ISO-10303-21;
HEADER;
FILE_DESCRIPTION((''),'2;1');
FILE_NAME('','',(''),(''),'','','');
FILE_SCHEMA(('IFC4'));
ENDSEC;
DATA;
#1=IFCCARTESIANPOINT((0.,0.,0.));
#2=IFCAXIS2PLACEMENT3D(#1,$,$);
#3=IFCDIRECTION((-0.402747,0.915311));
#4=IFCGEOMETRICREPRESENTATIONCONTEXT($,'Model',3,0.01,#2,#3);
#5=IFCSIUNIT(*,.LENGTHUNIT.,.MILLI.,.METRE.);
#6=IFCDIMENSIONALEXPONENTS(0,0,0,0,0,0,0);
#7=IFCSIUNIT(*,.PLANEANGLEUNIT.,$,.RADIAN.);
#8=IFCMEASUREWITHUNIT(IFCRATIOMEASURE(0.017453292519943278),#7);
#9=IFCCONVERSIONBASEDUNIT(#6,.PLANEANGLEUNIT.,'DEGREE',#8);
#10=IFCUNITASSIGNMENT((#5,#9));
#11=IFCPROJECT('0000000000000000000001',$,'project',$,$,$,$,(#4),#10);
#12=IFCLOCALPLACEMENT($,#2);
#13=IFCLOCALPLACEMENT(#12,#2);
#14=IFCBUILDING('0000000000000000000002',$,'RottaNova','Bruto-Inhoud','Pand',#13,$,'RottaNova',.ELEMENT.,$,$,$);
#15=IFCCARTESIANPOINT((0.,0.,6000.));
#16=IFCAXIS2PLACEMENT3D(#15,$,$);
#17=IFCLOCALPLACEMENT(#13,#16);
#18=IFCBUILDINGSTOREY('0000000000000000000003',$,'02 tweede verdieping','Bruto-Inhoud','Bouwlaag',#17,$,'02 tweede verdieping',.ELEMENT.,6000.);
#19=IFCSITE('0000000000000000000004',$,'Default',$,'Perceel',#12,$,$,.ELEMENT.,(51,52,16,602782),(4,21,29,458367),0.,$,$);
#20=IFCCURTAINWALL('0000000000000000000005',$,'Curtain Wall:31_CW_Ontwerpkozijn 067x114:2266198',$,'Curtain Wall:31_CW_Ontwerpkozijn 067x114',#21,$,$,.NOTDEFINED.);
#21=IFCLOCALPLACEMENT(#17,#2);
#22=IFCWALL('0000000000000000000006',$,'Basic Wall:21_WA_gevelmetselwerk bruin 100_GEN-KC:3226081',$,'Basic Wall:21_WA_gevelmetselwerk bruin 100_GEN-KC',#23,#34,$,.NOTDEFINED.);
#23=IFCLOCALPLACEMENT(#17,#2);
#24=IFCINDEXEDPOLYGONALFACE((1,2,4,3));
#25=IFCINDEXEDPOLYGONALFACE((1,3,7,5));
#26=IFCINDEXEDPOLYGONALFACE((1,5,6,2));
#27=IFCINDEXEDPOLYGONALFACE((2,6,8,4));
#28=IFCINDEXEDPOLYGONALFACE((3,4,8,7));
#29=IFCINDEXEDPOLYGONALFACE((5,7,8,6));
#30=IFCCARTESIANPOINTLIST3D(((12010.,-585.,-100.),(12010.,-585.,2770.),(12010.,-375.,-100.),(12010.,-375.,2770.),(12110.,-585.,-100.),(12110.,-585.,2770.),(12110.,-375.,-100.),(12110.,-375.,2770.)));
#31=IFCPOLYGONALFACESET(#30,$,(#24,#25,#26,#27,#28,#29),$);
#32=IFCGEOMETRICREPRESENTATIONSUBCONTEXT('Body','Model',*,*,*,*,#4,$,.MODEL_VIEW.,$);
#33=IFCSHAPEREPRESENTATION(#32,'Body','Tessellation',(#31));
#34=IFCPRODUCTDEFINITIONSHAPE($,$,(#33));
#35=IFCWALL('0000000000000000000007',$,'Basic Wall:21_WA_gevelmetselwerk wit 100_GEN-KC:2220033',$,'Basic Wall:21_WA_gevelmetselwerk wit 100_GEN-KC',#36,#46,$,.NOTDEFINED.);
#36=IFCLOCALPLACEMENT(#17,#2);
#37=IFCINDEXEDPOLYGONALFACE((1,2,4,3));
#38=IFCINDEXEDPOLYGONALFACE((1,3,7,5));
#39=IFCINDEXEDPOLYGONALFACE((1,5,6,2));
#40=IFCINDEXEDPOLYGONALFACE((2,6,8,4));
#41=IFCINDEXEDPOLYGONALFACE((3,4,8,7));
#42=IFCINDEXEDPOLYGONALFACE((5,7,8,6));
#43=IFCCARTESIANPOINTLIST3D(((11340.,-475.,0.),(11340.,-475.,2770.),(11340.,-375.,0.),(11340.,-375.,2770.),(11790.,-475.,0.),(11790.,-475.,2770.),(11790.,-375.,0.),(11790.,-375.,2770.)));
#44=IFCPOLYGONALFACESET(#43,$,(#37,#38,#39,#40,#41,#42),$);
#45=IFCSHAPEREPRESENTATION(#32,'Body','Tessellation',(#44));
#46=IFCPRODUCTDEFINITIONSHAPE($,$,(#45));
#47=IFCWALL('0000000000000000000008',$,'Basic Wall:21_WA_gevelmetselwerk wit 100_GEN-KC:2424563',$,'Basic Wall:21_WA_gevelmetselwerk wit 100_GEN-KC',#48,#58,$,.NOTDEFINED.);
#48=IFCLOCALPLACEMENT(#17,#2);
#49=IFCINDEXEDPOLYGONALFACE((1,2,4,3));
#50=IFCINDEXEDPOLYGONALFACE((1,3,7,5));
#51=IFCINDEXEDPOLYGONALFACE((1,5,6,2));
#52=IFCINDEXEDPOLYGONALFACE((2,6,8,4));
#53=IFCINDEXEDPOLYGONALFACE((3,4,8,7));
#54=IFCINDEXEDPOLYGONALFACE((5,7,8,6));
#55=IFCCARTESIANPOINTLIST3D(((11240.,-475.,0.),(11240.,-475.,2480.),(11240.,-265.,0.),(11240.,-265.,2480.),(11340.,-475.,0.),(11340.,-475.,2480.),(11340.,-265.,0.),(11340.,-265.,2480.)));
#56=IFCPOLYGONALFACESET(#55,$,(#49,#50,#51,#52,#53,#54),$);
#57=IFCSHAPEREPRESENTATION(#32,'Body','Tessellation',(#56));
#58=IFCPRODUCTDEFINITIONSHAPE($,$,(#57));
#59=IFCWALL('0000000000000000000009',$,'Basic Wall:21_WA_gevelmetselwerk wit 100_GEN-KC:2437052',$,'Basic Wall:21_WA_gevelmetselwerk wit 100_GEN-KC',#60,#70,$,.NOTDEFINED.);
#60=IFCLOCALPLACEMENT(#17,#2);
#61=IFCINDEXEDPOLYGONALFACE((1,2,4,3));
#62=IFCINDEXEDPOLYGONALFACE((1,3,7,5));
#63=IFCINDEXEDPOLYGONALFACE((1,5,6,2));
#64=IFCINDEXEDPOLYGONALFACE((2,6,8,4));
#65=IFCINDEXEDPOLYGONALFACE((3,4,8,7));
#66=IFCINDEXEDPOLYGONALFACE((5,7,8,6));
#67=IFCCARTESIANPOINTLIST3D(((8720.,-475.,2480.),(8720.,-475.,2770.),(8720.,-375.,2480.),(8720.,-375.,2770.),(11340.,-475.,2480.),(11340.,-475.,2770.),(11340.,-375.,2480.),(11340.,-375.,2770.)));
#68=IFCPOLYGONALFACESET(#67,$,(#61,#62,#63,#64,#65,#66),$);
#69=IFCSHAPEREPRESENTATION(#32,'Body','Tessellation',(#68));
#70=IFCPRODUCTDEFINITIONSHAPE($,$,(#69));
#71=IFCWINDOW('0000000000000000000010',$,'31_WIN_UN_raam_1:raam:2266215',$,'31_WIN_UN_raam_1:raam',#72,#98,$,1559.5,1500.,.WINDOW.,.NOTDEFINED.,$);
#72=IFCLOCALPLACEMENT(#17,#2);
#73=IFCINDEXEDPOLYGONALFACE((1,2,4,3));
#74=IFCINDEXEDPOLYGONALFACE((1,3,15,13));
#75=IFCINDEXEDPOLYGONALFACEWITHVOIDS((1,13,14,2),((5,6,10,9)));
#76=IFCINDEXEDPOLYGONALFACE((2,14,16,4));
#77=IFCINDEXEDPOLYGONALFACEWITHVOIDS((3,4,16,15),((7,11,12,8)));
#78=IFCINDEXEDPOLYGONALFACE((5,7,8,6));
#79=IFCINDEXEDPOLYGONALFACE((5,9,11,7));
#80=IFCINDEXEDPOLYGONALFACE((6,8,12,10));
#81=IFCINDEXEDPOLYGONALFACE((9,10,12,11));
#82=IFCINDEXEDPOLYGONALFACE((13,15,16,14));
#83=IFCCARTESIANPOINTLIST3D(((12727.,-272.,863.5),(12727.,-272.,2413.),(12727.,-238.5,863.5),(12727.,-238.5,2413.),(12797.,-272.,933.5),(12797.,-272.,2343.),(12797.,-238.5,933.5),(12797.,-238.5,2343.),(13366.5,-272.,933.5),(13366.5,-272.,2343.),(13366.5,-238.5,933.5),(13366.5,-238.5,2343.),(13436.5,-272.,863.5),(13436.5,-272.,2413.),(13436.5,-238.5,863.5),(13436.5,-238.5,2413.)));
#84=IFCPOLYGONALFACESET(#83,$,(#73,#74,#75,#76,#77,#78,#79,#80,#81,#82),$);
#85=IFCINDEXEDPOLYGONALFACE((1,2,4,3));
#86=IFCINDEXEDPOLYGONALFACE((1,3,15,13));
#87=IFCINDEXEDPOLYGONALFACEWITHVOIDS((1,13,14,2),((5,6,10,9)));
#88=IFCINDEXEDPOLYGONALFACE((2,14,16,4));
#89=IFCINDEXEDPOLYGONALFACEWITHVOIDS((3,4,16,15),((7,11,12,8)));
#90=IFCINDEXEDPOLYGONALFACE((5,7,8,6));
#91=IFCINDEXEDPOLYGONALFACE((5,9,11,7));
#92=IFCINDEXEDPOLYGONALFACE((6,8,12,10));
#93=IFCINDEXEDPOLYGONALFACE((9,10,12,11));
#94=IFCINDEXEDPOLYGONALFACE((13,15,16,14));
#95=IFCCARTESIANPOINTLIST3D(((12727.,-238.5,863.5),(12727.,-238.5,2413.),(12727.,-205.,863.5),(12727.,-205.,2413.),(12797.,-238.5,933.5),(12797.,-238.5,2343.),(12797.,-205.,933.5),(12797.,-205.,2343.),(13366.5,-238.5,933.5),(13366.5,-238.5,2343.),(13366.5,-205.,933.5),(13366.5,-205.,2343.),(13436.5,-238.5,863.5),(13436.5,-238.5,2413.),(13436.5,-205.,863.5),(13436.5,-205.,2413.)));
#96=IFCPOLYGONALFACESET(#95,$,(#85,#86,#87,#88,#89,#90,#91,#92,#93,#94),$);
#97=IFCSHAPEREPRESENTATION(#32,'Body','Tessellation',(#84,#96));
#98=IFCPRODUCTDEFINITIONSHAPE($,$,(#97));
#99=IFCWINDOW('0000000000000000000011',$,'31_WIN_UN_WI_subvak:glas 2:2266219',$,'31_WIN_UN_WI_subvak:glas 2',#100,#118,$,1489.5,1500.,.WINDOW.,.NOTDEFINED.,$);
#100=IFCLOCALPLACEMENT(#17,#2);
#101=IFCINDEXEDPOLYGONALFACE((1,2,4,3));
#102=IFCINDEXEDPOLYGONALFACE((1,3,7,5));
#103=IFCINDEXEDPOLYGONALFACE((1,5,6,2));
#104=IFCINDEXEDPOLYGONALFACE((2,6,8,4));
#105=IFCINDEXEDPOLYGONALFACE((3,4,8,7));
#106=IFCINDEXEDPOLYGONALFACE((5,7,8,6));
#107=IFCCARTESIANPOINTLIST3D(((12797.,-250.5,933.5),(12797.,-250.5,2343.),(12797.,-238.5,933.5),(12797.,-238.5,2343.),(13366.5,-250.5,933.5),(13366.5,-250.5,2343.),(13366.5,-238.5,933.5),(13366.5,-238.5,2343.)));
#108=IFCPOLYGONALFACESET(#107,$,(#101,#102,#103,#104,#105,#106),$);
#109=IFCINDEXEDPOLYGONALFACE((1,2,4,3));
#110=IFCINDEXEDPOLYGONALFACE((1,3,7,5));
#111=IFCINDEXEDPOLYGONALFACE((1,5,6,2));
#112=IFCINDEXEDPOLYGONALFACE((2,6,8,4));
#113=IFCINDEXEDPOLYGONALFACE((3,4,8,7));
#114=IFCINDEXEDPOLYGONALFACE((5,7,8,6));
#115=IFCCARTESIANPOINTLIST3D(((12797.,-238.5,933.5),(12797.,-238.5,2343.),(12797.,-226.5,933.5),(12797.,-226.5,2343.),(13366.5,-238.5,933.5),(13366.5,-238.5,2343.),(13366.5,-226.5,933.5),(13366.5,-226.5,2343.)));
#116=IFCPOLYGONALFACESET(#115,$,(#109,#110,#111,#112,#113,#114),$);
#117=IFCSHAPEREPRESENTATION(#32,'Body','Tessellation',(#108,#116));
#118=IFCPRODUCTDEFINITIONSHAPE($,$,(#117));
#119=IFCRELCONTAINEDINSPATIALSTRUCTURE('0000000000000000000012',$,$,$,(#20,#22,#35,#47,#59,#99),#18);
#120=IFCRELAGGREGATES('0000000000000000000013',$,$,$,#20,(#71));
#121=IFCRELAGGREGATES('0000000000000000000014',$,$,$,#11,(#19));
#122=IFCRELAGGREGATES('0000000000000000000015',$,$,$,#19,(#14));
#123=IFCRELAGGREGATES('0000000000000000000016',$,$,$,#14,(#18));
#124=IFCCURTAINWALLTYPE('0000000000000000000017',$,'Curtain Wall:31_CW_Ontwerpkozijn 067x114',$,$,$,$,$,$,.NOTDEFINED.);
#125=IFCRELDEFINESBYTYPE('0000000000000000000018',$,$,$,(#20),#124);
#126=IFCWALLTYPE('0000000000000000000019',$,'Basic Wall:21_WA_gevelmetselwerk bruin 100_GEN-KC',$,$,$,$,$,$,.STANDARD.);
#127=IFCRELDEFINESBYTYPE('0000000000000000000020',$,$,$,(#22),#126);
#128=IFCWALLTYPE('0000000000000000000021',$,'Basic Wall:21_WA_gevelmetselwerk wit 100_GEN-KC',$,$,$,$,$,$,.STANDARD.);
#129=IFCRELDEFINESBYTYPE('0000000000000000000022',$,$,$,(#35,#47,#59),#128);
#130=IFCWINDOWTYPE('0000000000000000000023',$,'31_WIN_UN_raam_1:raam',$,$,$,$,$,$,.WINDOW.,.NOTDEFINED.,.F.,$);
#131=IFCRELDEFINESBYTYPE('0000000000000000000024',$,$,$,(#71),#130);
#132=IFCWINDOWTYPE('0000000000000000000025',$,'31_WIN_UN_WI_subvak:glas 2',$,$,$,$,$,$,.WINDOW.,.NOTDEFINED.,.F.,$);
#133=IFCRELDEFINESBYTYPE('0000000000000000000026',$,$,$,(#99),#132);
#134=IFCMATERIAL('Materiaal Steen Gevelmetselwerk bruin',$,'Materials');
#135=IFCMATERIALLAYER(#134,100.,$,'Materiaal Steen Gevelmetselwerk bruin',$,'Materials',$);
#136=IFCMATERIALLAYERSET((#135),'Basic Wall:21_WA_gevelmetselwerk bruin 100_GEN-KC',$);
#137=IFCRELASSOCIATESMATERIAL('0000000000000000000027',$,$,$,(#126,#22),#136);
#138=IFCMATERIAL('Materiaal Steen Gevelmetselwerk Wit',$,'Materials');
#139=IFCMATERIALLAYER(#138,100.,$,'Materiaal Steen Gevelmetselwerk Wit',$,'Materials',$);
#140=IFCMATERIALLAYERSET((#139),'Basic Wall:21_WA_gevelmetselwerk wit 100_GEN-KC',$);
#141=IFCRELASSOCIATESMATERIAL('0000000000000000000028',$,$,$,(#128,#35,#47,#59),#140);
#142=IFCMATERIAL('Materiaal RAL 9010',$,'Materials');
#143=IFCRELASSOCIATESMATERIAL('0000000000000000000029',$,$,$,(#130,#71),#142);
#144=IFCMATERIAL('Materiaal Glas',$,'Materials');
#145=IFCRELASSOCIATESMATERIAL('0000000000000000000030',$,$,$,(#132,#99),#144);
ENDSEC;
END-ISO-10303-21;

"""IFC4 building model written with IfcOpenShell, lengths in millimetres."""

from ifc_helpers import new_model, entity, si_unit, converted_unit, direction, frame, frame_2d, origin, origin_2d_with_axis, place, context, subcontext, project, spatial, polyline, rectangle, outline, extrude, clip, bounded_halfspace, source, transform, mapped, material, layer, layer_set, type_object, type_shapes, element, aggregate, save


model = new_model("IFC4")

# Units and contexts
model_context = context("Model", 3, precision=0.01, world=origin(), true_north=direction((-0.402747, 0.915311)))
body_context = subcontext(model_context, "Body", "Model", "MODEL_VIEW")
ifc_project = project(units=[si_unit("LENGTHUNIT", "METRE", prefix="MILLI"), converted_unit("PLANEANGLEUNIT", "DEGREE", entity("IfcRatioMeasure", 0.017453292519943278), si_unit("PLANEANGLEUNIT", "RADIAN"), dimensions=[0, 0, 0, 0, 0, 0, 0])], contexts=[model_context])

# Site, building, storey
site_placement = place(None, origin())
site = spatial("IfcSite", under=ifc_project, at=site_placement, Name="Default", ObjectType="Perceel", CompositionType="ELEMENT", RefLatitude=(51, 52, 16, 602782), RefLongitude=(4, 21, 29, 458367), RefElevation=0.0)
building_placement = place(site_placement, origin())
building = spatial("IfcBuilding", under=site, at=building_placement, Name="RottaNova", Description="Bruto-Inhoud", ObjectType="Pand", LongName="RottaNova", CompositionType="ELEMENT")
storey_placement = place(building_placement, frame((0.0, 0.0, 6000.0)))
storey = spatial("IfcBuildingStorey", under=building, at=storey_placement, Name="02 tweede verdieping", Description="Bruto-Inhoud", ObjectType="Bouwlaag", LongName="02 tweede verdieping", CompositionType="ELEMENT", Elevation=6000.0)

# Curtain wall
curtain_wall_type = type_object("IfcCurtainWallType", Name="Curtain Wall:31_CW_Ontwerpkozijn 067x114", PredefinedType="NOTDEFINED")
curtain_wall_1_placement = place(storey_placement, frame((0.0, 0.0, -6000.0)))
curtain_wall_1 = element("IfcCurtainWall", 1, at=curtain_wall_1_placement, inside=storey, type_object=curtain_wall_type, Name="Curtain Wall:31_CW_Ontwerpkozijn 067x114:2266198", ObjectType="Curtain Wall:31_CW_Ontwerpkozijn 067x114", PredefinedType="NOTDEFINED")
ifc_material_1 = material(Name="Materiaal RAL 9010", Category="Materials")

# Shared definitions
ifc_material_2 = material(Name="Materiaal Glas", Category="Materials")

# Wall
ifc_material_3 = material(Name="Materiaal Steen Gevelmetselwerk bruin", Category="Materials")
ifc_layer_1 = layer(ifc_material_3, 100.0, Name="Materiaal Steen Gevelmetselwerk bruin", Category="Materials")
ifc_layer_set_1 = layer_set([ifc_layer_1], Name="Basic Wall:21_WA_gevelmetselwerk bruin 100_GEN-KC")
wall_type_1 = type_object("IfcWallType", Name="Basic Wall:21_WA_gevelmetselwerk bruin 100_GEN-KC", PredefinedType="STANDARD", material=ifc_layer_set_1)
wall_1_placement = place(storey_placement, frame((12060.0, -585.0, -100.0), z_axis=(0.0, 0.0, 1.0), x_axis=(0.0, 1.0, 0.0)))
element("IfcWall", 2, at=wall_1_placement, inside=storey, type_object=wall_type_1, material=ifc_layer_set_1, Name="Basic Wall:21_WA_gevelmetselwerk bruin 100_GEN-KC:3226081", ObjectType="Basic Wall:21_WA_gevelmetselwerk bruin 100_GEN-KC", PredefinedType="NOTDEFINED", context=body_context, shape_type="SweptSolid", body=[
    extrude(rectangle(XDim=210.0, YDim=100.0, at=frame_2d((105.0, 0.0), x_axis=(-1.0, 0.0))), origin(), (0.0, 0.0, 1.0), 2870.0),
])

# Walls
ifc_material_4 = material(Name="Materiaal Steen Gevelmetselwerk Wit", Category="Materials")
ifc_layer_2 = layer(ifc_material_4, 100.0, Name="Materiaal Steen Gevelmetselwerk Wit", Category="Materials")
ifc_layer_set_2 = layer_set([ifc_layer_2], Name="Basic Wall:21_WA_gevelmetselwerk wit 100_GEN-KC")
wall_type_2 = type_object("IfcWallType", Name="Basic Wall:21_WA_gevelmetselwerk wit 100_GEN-KC", PredefinedType="STANDARD", material=ifc_layer_set_2)
wall_2_placement = place(storey_placement, frame((11790.0, -425.0, 0.0), z_axis=(0.0, 0.0, 1.0), x_axis=(-1.0, 0.0, 0.0)))
element("IfcWall", 3, at=wall_2_placement, inside=storey, type_object=wall_type_2, material=ifc_layer_set_2, Name="Basic Wall:21_WA_gevelmetselwerk wit 100_GEN-KC:2220033", ObjectType="Basic Wall:21_WA_gevelmetselwerk wit 100_GEN-KC", PredefinedType="NOTDEFINED", context=body_context, shape_type="SweptSolid", body=[
    extrude(rectangle(XDim=450.0, YDim=100.0, at=frame_2d((225.0, 0.0), x_axis=(-1.0, 0.0))), origin(), (0.0, 0.0, 1.0), 2770.0),
])
wall_3_placement = place(storey_placement, frame((11290.0, -265.0, 0.0), z_axis=(0.0, 0.0, 1.0), x_axis=(0.0, -1.0, 0.0)))
element("IfcWall", 4, at=wall_3_placement, inside=storey, type_object=wall_type_2, material=ifc_layer_set_2, Name="Basic Wall:21_WA_gevelmetselwerk wit 100_GEN-KC:2424563", ObjectType="Basic Wall:21_WA_gevelmetselwerk wit 100_GEN-KC", PredefinedType="NOTDEFINED", context=body_context, shape_type="SweptSolid", body=[
    extrude(rectangle(XDim=210.0, YDim=100.0, at=frame_2d((105.0, 0.0), x_axis=(-1.0, 0.0))), origin(), (0.0, 0.0, 1.0), 2480.0),
])
wall_4_placement = place(storey_placement, frame((11340.0, -425.0, 2480.0), z_axis=(0.0, 0.0, 1.0), x_axis=(-1.0, 0.0, 0.0)))
element("IfcWall", 5, at=wall_4_placement, inside=storey, type_object=wall_type_2, material=ifc_layer_set_2, Name="Basic Wall:21_WA_gevelmetselwerk wit 100_GEN-KC:2437052", ObjectType="Basic Wall:21_WA_gevelmetselwerk wit 100_GEN-KC", PredefinedType="NOTDEFINED", context=body_context, shape_type="Clipping", body=[
    clip(extrude(rectangle(XDim=2620.0, YDim=100.0, at=frame_2d((1310.0, 0.0), x_axis=(-1.0, 0.0))), origin(), (0.0, 0.0, 1.0), 290.0), bounded_halfspace(frame((2620.0, -50.0, 290.0), z_axis=(1.0, 0.0, 0.0), x_axis=(0.0, 1.0, 0.0)), False, frame((2620.0, -50.0, 290.0), z_axis=(1.0, 0.0, 0.0), x_axis=(0.0, 1.0, 0.0)), polyline([(0.0, 0.0), (0.0, -88392.0), (30480.0, -88392.0), (30480.0, 0.0), (0.0, 0.0)]))),
])

# Windows
window_type_1 = type_object("IfcWindowType", Name="31_WIN_UN_raam_1:raam", ParameterTakesPrecedence=False, PartitioningType="NOTDEFINED", PredefinedType="WINDOW", material=ifc_material_1)
shared_shape_1 = source(origin(), body_context, "Body", "SweptSolid", [
    extrude(outline(polyline([(-354.7, -774.7), (354.7, -774.7), (354.7, 774.7), (-354.7, 774.7), (-354.7, -774.7)]), holes=[polyline([(-284.7, 704.7), (284.7, 704.7), (284.7, -704.8), (-284.7, -704.8), (-284.7, 704.7)])]), frame((0.0, 92.0, 774.8), z_axis=(0.0, -1.0, 0.0), x_axis=(-1.0, 0.0, 0.0)), (0.0, 0.0, 1.0), 33.5),
    extrude(outline(polyline([(-354.7, -774.7), (354.7, -774.7), (354.7, 774.7), (-354.7, 774.7), (-354.7, -774.7)]), holes=[polyline([(-284.7, 704.7), (284.7, 704.7), (284.7, -704.8), (-284.7, -704.8), (-284.7, 704.7)])]), frame((0.0, 58.5, 774.8), z_axis=(0.0, -1.0, 0.0), x_axis=(-1.0, 0.0, 0.0)), (0.0, 0.0, 1.0), 33.5),
])
type_shapes(window_type_1, [shared_shape_1])
window_1_placement = place(curtain_wall_1_placement, frame((13081.8, -180.0, 6863.5), z_axis=(0.0, 0.0, 1.0), x_axis=(-1.0, 0.0, 0.0)))
window_1 = element("IfcWindow", 6, at=window_1_placement, type_object=window_type_1, material=ifc_material_1, Name="31_WIN_UN_raam_1:raam:2266215", ObjectType="31_WIN_UN_raam_1:raam", OverallHeight=1559.5, OverallWidth=1500.0, PartitioningType="NOTDEFINED", PredefinedType="WINDOW", context=body_context, shape_type="MappedRepresentation", body=[
    mapped(shared_shape_1, transform((0.0, 0.0, 0.0), scale=1.0)),
])
aggregate(curtain_wall_1, [window_1])
window_type_2 = type_object("IfcWindowType", Name="31_WIN_UN_WI_subvak:glas 2", ParameterTakesPrecedence=False, PartitioningType="NOTDEFINED", PredefinedType="WINDOW", material=ifc_material_2)
shared_shape_2 = source(origin(), body_context, "Body", "SweptSolid", [
    extrude(rectangle(XDim=569.5, YDim=12.0, at=origin_2d_with_axis()), frame((0.0, -6.0, 0.0)), (0.0, 0.0, 1.0), 1409.5),
    extrude(rectangle(XDim=569.5, YDim=12.0, at=origin_2d_with_axis()), frame((0.0, 6.0, 0.0)), (0.0, 0.0, 1.0), 1409.5),
])
type_shapes(window_type_2, [shared_shape_2])
window_2_placement = place(storey_placement, frame((13081.8, -238.5, 933.5)))
element("IfcWindow", 7, at=window_2_placement, inside=storey, type_object=window_type_2, material=ifc_material_2, Name="31_WIN_UN_WI_subvak:glas 2:2266219", ObjectType="31_WIN_UN_WI_subvak:glas 2", OverallHeight=1489.5, OverallWidth=1500.0, PartitioningType="NOTDEFINED", PredefinedType="WINDOW", context=body_context, shape_type="MappedRepresentation", body=[
    mapped(shared_shape_2, transform((0.0, 0.0, 0.0), scale=1.0)),
])

save(model, "model.ifc")
